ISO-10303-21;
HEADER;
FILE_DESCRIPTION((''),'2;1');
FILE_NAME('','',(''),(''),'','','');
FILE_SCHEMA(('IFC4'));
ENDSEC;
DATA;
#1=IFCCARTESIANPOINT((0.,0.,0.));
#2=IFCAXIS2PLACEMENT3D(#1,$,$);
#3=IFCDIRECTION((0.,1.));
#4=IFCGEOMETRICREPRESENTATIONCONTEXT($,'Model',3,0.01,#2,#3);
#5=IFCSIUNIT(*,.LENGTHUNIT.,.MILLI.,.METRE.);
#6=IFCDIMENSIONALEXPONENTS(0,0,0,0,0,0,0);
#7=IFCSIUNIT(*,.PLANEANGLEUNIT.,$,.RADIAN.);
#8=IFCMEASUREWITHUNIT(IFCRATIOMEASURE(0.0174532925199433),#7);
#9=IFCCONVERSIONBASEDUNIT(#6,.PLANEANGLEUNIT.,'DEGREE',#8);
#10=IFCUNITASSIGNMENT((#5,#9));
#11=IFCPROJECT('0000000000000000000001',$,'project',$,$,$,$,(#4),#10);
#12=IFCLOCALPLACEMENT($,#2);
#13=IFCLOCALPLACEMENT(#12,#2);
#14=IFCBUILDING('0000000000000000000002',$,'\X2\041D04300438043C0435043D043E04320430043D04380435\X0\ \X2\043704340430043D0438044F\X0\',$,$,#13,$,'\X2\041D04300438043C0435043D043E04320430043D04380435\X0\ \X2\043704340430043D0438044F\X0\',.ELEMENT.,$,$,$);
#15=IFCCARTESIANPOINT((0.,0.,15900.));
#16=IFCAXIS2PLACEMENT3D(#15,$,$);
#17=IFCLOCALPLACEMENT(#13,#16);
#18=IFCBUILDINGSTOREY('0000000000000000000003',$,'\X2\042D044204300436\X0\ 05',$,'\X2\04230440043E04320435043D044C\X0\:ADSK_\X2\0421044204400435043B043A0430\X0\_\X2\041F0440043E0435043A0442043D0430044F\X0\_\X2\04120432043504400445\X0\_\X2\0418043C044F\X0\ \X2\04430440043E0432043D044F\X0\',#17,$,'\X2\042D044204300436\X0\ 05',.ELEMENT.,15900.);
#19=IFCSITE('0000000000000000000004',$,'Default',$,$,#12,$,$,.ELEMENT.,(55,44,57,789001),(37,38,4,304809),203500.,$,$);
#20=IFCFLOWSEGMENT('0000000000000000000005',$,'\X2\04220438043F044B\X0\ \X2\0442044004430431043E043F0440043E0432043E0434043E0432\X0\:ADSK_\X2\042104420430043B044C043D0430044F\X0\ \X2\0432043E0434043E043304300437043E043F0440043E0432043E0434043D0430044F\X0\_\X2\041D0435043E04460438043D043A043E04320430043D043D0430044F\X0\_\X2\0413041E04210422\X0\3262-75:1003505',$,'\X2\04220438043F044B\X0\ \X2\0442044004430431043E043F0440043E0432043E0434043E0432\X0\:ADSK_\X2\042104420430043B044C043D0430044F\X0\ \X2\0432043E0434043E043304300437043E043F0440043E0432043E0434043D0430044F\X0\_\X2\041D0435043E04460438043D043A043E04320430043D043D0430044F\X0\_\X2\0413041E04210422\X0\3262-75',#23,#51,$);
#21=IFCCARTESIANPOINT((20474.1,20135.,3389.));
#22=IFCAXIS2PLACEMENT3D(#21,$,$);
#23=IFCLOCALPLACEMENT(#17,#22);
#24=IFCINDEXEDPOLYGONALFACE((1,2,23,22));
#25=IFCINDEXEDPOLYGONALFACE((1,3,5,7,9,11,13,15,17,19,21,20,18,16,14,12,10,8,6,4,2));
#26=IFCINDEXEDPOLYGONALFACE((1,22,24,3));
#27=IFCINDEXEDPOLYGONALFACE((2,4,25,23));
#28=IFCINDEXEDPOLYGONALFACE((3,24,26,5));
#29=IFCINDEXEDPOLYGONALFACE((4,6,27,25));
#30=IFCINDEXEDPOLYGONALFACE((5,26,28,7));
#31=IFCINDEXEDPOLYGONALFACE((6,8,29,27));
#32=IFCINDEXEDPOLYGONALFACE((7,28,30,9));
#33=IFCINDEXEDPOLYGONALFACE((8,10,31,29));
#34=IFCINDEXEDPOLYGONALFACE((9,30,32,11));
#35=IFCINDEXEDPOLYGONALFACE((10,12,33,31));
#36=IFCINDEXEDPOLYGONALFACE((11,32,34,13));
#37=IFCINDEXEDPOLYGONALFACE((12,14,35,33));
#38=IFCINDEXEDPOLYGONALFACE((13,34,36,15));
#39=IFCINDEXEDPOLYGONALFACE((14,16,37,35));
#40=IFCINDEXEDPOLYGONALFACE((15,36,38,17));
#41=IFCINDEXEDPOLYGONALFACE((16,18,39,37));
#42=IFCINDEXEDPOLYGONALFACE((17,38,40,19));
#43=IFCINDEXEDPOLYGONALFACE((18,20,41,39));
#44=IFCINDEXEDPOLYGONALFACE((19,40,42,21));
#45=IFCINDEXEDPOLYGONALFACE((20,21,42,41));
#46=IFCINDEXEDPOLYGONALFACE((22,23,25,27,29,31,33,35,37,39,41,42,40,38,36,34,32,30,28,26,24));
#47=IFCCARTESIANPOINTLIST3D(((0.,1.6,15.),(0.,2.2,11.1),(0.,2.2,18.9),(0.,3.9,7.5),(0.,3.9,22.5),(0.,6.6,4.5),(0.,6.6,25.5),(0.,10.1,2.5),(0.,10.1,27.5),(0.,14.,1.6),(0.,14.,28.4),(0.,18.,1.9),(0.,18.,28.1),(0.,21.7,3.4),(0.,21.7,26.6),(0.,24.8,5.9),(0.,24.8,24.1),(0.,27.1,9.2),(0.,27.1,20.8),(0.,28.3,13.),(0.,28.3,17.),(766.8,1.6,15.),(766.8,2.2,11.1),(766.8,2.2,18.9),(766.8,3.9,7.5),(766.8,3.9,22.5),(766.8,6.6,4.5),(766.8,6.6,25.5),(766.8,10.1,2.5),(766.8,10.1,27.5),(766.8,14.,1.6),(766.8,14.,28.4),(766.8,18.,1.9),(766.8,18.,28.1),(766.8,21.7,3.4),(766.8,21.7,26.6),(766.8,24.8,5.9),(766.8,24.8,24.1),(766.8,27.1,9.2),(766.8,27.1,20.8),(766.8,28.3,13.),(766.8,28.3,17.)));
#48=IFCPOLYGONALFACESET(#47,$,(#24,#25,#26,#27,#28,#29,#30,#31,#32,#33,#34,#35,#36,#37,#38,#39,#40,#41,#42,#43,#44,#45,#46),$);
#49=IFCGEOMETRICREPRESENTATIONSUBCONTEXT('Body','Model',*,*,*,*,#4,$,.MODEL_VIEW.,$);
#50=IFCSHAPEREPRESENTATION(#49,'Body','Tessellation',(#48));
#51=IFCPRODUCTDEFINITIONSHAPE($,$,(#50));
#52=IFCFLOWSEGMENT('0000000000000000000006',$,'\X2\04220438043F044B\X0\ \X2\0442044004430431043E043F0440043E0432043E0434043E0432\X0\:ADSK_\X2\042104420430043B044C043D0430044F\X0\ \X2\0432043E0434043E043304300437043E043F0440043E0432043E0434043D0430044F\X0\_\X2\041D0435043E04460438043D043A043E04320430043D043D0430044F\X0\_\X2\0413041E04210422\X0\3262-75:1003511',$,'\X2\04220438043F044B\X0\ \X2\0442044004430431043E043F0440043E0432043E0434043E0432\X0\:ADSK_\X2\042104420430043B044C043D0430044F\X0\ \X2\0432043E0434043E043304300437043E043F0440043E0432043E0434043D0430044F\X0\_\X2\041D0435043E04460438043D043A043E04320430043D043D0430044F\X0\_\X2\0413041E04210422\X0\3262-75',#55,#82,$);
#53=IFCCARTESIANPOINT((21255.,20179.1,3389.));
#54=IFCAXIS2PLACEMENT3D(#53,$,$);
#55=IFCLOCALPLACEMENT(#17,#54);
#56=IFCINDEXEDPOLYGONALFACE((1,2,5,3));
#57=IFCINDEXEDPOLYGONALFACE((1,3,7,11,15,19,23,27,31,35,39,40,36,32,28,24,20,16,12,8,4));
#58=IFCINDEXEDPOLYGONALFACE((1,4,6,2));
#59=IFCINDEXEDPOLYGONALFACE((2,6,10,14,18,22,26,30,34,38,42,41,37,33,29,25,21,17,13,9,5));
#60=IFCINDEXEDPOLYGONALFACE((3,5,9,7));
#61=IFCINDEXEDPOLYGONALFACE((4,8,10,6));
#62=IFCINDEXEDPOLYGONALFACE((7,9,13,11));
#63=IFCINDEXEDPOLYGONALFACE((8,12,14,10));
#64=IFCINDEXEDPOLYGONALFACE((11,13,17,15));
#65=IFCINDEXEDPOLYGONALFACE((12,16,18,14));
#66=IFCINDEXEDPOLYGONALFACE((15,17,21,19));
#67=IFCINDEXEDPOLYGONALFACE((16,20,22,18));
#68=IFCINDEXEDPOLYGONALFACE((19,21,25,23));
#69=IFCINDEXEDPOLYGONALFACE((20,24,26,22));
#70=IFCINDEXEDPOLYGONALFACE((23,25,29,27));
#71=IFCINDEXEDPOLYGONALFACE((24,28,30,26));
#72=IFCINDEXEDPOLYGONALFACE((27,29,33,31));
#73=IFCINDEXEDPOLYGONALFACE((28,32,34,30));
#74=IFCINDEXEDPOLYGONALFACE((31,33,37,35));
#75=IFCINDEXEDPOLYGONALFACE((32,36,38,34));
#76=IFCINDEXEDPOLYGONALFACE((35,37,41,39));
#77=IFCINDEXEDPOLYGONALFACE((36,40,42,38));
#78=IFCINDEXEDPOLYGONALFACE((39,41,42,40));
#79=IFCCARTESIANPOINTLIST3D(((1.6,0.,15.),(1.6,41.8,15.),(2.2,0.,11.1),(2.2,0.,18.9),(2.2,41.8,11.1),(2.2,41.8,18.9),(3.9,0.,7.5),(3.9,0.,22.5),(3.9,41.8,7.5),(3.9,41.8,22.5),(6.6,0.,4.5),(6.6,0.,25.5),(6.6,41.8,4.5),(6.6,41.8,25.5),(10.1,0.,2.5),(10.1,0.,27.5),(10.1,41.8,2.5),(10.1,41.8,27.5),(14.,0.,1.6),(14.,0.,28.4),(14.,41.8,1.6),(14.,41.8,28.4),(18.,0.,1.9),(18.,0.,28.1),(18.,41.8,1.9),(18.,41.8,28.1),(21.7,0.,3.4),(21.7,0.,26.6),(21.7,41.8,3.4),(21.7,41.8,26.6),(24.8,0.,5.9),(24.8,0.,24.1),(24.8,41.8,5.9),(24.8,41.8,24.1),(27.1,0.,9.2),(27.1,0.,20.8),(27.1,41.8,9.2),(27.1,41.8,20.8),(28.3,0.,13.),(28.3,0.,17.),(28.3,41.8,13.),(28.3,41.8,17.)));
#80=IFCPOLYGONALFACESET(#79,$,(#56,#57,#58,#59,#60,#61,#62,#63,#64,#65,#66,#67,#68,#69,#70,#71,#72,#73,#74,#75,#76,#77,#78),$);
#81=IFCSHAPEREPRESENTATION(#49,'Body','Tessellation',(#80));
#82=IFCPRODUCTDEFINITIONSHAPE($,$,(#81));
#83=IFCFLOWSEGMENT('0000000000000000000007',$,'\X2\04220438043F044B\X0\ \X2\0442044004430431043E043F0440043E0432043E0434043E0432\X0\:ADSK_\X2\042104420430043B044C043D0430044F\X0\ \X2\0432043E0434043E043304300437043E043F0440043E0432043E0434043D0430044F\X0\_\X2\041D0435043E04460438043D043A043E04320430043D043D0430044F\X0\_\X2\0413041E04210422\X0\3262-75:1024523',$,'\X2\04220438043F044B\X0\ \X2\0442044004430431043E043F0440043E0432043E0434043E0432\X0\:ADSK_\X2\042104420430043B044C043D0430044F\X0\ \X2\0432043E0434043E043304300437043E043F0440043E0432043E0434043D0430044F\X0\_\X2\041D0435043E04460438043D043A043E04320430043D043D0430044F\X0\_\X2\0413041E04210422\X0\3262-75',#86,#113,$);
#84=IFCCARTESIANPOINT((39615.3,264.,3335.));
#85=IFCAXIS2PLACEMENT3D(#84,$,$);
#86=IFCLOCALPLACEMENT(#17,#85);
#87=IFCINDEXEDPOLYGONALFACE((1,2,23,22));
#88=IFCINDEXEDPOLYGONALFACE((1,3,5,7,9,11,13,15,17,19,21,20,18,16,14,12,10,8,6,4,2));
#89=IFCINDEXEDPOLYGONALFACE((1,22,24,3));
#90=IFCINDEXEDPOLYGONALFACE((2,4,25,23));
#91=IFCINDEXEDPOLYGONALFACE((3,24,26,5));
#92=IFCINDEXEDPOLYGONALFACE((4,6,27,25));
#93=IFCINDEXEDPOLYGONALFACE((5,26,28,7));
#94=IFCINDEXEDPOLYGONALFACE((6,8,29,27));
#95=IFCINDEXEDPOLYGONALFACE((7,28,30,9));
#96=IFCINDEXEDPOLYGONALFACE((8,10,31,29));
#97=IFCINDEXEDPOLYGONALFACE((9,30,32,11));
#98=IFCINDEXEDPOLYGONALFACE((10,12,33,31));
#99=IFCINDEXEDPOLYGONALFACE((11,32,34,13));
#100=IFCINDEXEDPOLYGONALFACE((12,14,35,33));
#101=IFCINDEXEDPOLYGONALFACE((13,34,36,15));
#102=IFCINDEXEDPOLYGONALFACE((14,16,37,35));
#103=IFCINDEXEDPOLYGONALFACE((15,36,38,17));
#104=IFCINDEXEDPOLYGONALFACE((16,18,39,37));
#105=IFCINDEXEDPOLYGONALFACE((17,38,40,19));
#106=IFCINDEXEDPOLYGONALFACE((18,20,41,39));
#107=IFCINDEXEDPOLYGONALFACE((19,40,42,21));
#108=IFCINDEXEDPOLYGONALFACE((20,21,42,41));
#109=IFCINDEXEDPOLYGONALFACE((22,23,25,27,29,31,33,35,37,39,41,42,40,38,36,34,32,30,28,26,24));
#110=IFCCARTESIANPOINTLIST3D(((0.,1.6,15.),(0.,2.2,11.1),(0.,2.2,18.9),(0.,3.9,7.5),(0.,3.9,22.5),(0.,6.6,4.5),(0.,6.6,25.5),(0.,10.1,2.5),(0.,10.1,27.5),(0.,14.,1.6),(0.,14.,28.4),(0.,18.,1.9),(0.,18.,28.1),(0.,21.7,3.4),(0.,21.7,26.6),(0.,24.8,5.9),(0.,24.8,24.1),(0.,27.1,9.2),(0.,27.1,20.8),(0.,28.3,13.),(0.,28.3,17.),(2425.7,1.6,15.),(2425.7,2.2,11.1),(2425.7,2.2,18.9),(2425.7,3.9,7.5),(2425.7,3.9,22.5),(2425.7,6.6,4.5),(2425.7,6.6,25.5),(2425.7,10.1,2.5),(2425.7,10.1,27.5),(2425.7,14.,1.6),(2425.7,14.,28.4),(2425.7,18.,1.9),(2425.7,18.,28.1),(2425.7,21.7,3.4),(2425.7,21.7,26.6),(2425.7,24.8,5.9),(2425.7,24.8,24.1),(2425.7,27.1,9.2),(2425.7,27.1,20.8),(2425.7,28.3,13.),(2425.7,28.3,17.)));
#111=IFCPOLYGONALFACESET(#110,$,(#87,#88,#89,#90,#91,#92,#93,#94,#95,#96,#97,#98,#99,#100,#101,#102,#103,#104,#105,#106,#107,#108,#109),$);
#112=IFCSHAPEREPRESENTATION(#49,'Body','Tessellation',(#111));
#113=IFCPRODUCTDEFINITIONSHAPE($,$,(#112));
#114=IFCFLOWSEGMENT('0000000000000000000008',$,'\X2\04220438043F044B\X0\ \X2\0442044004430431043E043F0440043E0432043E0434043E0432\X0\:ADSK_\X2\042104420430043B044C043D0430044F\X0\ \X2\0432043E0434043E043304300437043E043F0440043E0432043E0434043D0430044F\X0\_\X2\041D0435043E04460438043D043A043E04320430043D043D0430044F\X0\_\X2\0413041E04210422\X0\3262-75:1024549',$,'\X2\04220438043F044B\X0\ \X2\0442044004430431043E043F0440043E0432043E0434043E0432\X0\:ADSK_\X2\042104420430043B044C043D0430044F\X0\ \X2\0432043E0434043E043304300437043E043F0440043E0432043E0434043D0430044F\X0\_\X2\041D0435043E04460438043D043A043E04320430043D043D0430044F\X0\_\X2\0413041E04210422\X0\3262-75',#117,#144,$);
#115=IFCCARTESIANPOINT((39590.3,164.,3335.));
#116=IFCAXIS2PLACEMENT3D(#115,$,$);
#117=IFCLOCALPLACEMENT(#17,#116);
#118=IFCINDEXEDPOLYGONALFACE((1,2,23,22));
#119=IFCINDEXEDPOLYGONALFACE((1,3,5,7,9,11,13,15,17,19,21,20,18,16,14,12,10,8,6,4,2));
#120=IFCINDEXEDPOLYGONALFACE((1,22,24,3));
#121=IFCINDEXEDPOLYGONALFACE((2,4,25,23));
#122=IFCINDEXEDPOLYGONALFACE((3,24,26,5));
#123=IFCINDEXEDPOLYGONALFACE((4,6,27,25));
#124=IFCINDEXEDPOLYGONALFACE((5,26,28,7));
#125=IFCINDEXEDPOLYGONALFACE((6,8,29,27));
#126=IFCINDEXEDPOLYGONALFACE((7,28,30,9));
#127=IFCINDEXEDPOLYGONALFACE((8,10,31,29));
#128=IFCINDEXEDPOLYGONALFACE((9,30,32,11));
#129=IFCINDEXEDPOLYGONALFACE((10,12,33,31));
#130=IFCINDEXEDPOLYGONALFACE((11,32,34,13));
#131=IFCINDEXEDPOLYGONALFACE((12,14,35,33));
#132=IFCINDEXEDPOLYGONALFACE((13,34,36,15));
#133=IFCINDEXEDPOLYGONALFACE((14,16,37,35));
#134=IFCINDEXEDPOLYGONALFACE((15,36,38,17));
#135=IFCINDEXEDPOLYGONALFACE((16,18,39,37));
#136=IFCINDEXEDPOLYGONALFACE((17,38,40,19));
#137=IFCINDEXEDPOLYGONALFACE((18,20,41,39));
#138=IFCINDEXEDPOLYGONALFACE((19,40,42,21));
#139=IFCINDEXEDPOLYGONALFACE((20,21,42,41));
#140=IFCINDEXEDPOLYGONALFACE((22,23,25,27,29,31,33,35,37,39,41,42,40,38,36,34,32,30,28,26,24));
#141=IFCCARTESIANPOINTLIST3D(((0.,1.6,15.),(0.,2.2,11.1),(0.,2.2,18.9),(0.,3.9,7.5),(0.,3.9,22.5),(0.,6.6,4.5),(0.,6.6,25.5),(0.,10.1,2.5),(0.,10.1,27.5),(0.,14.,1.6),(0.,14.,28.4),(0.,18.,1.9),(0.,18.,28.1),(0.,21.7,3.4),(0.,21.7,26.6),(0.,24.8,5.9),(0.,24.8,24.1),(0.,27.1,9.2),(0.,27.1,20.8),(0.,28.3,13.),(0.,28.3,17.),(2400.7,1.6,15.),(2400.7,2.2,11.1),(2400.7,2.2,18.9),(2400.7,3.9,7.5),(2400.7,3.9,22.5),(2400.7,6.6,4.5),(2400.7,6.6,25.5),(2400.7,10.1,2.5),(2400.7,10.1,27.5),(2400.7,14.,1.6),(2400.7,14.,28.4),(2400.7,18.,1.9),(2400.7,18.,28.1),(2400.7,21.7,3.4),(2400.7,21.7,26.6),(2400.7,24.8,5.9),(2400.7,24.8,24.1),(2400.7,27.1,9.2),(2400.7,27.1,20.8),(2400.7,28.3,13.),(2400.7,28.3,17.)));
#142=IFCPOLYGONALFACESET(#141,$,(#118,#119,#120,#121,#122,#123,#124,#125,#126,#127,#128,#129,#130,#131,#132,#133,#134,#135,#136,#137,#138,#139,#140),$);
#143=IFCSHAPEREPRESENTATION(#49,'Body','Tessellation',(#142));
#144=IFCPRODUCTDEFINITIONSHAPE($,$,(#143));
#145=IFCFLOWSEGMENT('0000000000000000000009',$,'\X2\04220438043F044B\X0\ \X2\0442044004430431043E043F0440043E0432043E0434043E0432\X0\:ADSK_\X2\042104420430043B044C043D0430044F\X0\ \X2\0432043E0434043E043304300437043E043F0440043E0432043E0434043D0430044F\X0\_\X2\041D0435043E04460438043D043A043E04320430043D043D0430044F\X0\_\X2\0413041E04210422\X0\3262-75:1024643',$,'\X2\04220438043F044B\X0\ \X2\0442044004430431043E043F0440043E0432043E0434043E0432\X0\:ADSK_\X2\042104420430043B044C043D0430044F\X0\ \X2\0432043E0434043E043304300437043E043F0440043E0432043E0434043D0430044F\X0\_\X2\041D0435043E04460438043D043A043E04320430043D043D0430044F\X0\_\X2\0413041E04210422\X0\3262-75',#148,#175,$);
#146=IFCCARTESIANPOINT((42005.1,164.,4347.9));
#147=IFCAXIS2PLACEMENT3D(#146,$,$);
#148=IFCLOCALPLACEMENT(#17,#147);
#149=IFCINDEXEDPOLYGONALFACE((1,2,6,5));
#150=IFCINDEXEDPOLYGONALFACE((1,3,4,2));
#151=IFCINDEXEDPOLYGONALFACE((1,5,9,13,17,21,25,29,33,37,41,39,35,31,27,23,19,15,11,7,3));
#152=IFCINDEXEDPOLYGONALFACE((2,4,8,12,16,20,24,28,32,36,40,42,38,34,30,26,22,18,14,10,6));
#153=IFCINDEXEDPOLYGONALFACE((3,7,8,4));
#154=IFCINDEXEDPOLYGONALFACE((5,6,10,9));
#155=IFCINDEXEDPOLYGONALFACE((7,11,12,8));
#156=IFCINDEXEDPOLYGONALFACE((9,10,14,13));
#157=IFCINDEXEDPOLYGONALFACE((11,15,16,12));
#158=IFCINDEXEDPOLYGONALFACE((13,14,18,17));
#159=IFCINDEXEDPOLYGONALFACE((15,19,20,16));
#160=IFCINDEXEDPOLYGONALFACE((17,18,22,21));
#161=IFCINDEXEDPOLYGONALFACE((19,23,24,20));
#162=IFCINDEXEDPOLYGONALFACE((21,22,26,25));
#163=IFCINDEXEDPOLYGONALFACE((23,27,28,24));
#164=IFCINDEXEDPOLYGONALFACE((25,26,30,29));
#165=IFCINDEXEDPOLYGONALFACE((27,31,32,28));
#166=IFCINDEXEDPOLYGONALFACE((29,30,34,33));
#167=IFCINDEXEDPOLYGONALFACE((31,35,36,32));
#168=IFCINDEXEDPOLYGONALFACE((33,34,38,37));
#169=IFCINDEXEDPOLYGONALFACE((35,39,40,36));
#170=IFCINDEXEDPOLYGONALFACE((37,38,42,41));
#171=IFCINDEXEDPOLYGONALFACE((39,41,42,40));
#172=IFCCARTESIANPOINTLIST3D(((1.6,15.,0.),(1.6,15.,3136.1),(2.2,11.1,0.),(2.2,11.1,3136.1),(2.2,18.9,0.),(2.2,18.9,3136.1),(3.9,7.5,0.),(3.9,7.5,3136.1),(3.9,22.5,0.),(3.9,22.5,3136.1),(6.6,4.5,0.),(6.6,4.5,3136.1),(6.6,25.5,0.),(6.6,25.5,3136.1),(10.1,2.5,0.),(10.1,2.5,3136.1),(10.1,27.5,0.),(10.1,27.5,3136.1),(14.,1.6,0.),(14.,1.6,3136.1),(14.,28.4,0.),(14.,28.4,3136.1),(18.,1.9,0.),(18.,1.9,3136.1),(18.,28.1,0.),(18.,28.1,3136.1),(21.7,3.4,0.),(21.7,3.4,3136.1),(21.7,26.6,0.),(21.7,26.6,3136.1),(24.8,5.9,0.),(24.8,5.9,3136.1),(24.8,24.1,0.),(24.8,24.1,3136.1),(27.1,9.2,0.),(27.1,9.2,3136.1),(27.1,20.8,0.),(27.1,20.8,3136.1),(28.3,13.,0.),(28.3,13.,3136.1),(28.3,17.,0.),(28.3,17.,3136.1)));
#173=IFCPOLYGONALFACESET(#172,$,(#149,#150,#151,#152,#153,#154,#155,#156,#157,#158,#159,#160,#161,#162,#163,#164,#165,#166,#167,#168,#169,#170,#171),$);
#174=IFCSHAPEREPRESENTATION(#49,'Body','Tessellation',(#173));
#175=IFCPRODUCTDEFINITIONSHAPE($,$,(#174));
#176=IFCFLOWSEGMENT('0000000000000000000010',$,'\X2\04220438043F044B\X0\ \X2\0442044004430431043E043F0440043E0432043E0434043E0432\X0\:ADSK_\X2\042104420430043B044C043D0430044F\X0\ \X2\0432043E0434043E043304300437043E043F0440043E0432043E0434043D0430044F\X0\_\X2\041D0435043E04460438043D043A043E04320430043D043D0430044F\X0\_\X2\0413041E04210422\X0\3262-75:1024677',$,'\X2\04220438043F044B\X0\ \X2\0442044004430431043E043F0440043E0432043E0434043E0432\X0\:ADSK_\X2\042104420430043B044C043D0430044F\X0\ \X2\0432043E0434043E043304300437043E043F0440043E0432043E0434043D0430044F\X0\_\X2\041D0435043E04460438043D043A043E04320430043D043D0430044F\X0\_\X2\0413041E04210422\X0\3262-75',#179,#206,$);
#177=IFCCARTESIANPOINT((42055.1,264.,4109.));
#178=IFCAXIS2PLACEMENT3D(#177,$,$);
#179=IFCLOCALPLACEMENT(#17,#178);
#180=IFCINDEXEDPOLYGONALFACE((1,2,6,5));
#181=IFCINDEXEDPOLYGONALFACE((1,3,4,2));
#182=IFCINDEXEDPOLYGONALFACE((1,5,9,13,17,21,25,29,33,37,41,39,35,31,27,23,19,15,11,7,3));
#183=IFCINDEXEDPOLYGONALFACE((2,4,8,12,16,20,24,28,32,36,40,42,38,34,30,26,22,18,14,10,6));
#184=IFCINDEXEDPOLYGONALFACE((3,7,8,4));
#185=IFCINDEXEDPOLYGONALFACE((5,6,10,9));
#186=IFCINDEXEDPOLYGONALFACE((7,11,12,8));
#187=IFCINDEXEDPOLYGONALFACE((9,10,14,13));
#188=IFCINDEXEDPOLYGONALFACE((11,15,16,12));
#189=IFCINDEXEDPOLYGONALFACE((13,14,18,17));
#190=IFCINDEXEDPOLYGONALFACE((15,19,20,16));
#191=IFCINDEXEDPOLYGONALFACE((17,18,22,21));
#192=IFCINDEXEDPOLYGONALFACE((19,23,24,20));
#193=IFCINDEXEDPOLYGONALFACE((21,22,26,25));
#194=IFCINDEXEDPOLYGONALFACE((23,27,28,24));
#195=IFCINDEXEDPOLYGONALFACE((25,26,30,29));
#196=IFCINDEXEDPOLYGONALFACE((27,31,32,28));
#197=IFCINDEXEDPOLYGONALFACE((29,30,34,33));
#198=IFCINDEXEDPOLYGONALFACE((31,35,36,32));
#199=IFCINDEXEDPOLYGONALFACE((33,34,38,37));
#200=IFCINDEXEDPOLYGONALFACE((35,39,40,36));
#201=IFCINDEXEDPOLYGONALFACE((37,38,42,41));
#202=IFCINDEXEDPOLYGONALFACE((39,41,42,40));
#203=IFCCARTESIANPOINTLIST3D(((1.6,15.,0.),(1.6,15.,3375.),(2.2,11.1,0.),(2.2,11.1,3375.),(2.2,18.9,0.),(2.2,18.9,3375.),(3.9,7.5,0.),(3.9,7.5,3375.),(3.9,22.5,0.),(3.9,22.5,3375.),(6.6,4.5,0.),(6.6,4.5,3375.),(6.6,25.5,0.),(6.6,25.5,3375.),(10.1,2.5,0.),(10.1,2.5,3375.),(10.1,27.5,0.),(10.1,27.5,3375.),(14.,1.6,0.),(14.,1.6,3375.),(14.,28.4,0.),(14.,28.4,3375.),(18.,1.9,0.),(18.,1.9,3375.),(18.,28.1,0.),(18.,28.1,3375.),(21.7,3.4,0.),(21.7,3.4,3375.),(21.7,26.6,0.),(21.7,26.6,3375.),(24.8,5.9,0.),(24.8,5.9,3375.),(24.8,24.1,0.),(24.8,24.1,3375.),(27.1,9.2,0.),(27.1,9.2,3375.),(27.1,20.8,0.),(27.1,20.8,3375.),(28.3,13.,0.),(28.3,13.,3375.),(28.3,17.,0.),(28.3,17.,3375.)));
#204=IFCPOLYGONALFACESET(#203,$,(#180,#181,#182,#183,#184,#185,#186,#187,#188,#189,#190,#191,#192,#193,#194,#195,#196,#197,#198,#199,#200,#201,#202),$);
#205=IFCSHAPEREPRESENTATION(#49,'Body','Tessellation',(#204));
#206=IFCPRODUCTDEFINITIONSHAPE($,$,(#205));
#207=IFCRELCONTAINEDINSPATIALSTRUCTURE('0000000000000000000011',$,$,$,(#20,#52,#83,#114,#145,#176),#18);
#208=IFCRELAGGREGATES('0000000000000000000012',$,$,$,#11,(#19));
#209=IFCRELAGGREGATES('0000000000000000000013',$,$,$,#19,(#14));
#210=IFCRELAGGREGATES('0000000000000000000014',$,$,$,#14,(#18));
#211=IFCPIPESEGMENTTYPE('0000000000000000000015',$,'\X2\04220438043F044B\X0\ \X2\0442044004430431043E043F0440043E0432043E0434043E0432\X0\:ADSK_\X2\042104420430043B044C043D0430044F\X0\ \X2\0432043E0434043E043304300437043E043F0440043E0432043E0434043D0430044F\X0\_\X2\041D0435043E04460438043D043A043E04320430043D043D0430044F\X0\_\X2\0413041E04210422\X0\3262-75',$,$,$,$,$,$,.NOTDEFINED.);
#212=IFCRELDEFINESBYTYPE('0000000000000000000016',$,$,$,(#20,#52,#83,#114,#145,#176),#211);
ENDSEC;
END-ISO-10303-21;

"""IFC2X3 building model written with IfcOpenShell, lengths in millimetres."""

from ifc_helpers import new_model, entity, si_unit, converted_unit, direction, frame, origin, origin_2d_with_axis, place, context, subcontext, project, spatial, circle, extrude, type_object, element, save


model = new_model("IFC2X3")

# Units and contexts
model_context = context("Model", 3, precision=0.01, world=origin(), true_north=direction((0.0, 1.0)))
body_context = subcontext(model_context, "Body", "Model", "MODEL_VIEW")
ifc_project = project(units=[si_unit("LENGTHUNIT", "METRE", prefix="MILLI"), converted_unit("PLANEANGLEUNIT", "DEGREE", entity("IfcRatioMeasure", 0.0174532925199433), si_unit("PLANEANGLEUNIT", "RADIAN"), dimensions=[0, 0, 0, 0, 0, 0, 0])], contexts=[model_context])

# Site, building, storey
site_placement = place(None, origin())
site = spatial("IfcSite", under=ifc_project, at=site_placement, Name="Default", CompositionType="ELEMENT", RefLatitude=(55, 44, 57, 789001), RefLongitude=(37, 38, 4, 304809), RefElevation=203500.0)
building_placement = place(site_placement, origin())
building = spatial("IfcBuilding", under=site, at=building_placement, Name="Наименование здания", LongName="Наименование здания", CompositionType="ELEMENT")
storey_placement = place(building_placement, frame((0.0, 0.0, 15900.0)))
storey = spatial("IfcBuildingStorey", under=building, at=storey_placement, Name="Этаж 05", ObjectType="Уровень:ADSK_Стрелка_Проектная_Вверх_Имя уровня", LongName="Этаж 05", CompositionType="ELEMENT", Elevation=15900.0)

# Flow segments
pipe_segment_type = type_object("IfcPipeSegmentType", Name="Типы трубопроводов:ADSK_Стальная водогазопроводная_Неоцинкованная_ГОСТ3262-75", PredefinedType="NOTDEFINED")
flow_segment_1_placement = place(storey_placement, frame((20474.1, 20135.0, 3389.0)))
element("IfcFlowSegment", 1, at=flow_segment_1_placement, inside=storey, type_object=pipe_segment_type, Name="Типы трубопроводов:ADSK_Стальная водогазопроводная_Неоцинкованная_ГОСТ3262-75:1003505", ObjectType="Типы трубопроводов:ADSK_Стальная водогазопроводная_Неоцинкованная_ГОСТ3262-75", context=body_context, shape_type="SweptSolid", body=[
    extrude(circle(Radius=13.4, at=origin_2d_with_axis()), frame((0.0, 15.0, 15.0), z_axis=(1.0, 0.0, 0.0), x_axis=(0.0, -1.0, 0.0)), (0.0, 0.0, 1.0), 766.8),
])
flow_segment_2_placement = place(storey_placement, frame((21255.0, 20179.1, 3389.0)))
element("IfcFlowSegment", 2, at=flow_segment_2_placement, inside=storey, type_object=pipe_segment_type, Name="Типы трубопроводов:ADSK_Стальная водогазопроводная_Неоцинкованная_ГОСТ3262-75:1003511", ObjectType="Типы трубопроводов:ADSK_Стальная водогазопроводная_Неоцинкованная_ГОСТ3262-75", context=body_context, shape_type="SweptSolid", body=[
    extrude(circle(Radius=13.4, at=origin_2d_with_axis()), frame((15.0, 0.0, 15.0), z_axis=(0.0, 1.0, 0.0), x_axis=(-1.0, 0.0, 0.0)), (0.0, 0.0, 1.0), 41.8),
])
flow_segment_3_placement = place(storey_placement, frame((39615.3, 264.0, 3335.0)))
element("IfcFlowSegment", 3, at=flow_segment_3_placement, inside=storey, type_object=pipe_segment_type, Name="Типы трубопроводов:ADSK_Стальная водогазопроводная_Неоцинкованная_ГОСТ3262-75:1024523", ObjectType="Типы трубопроводов:ADSK_Стальная водогазопроводная_Неоцинкованная_ГОСТ3262-75", context=body_context, shape_type="SweptSolid", body=[
    extrude(circle(Radius=13.4, at=origin_2d_with_axis()), frame((0.0, 15.0, 15.0), z_axis=(1.0, 0.0, 0.0), x_axis=(0.0, -1.0, 0.0)), (0.0, 0.0, 1.0), 2425.7),
])
flow_segment_4_placement = place(storey_placement, frame((39590.3, 164.0, 3335.0)))
element("IfcFlowSegment", 4, at=flow_segment_4_placement, inside=storey, type_object=pipe_segment_type, Name="Типы трубопроводов:ADSK_Стальная водогазопроводная_Неоцинкованная_ГОСТ3262-75:1024549", ObjectType="Типы трубопроводов:ADSK_Стальная водогазопроводная_Неоцинкованная_ГОСТ3262-75", context=body_context, shape_type="SweptSolid", body=[
    extrude(circle(Radius=13.4, at=origin_2d_with_axis()), frame((0.0, 15.0, 15.0), z_axis=(1.0, 0.0, 0.0), x_axis=(0.0, -1.0, 0.0)), (0.0, 0.0, 1.0), 2400.7),
])
flow_segment_5_placement = place(storey_placement, frame((42005.1, 164.0, 4347.9)))
element("IfcFlowSegment", 5, at=flow_segment_5_placement, inside=storey, type_object=pipe_segment_type, Name="Типы трубопроводов:ADSK_Стальная водогазопроводная_Неоцинкованная_ГОСТ3262-75:1024643", ObjectType="Типы трубопроводов:ADSK_Стальная водогазопроводная_Неоцинкованная_ГОСТ3262-75", context=body_context, shape_type="SweptSolid", body=[
    extrude(circle(Radius=13.4, at=origin_2d_with_axis()), frame((15.0, 15.0, 0.0), z_axis=(0.0, 0.0, 1.0), x_axis=(-1.0, 0.0, 0.0)), (0.0, 0.0, 1.0), 3136.1),
])
flow_segment_6_placement = place(storey_placement, frame((42055.1, 264.0, 4109.0)))
element("IfcFlowSegment", 6, at=flow_segment_6_placement, inside=storey, type_object=pipe_segment_type, Name="Типы трубопроводов:ADSK_Стальная водогазопроводная_Неоцинкованная_ГОСТ3262-75:1024677", ObjectType="Типы трубопроводов:ADSK_Стальная водогазопроводная_Неоцинкованная_ГОСТ3262-75", context=body_context, shape_type="SweptSolid", body=[
    extrude(circle(Radius=13.4, at=origin_2d_with_axis()), frame((15.0, 15.0, 0.0), z_axis=(0.0, 0.0, 1.0), x_axis=(-1.0, 0.0, 0.0)), (0.0, 0.0, 1.0), 3375.0),
])

save(model, "model.ifc")
